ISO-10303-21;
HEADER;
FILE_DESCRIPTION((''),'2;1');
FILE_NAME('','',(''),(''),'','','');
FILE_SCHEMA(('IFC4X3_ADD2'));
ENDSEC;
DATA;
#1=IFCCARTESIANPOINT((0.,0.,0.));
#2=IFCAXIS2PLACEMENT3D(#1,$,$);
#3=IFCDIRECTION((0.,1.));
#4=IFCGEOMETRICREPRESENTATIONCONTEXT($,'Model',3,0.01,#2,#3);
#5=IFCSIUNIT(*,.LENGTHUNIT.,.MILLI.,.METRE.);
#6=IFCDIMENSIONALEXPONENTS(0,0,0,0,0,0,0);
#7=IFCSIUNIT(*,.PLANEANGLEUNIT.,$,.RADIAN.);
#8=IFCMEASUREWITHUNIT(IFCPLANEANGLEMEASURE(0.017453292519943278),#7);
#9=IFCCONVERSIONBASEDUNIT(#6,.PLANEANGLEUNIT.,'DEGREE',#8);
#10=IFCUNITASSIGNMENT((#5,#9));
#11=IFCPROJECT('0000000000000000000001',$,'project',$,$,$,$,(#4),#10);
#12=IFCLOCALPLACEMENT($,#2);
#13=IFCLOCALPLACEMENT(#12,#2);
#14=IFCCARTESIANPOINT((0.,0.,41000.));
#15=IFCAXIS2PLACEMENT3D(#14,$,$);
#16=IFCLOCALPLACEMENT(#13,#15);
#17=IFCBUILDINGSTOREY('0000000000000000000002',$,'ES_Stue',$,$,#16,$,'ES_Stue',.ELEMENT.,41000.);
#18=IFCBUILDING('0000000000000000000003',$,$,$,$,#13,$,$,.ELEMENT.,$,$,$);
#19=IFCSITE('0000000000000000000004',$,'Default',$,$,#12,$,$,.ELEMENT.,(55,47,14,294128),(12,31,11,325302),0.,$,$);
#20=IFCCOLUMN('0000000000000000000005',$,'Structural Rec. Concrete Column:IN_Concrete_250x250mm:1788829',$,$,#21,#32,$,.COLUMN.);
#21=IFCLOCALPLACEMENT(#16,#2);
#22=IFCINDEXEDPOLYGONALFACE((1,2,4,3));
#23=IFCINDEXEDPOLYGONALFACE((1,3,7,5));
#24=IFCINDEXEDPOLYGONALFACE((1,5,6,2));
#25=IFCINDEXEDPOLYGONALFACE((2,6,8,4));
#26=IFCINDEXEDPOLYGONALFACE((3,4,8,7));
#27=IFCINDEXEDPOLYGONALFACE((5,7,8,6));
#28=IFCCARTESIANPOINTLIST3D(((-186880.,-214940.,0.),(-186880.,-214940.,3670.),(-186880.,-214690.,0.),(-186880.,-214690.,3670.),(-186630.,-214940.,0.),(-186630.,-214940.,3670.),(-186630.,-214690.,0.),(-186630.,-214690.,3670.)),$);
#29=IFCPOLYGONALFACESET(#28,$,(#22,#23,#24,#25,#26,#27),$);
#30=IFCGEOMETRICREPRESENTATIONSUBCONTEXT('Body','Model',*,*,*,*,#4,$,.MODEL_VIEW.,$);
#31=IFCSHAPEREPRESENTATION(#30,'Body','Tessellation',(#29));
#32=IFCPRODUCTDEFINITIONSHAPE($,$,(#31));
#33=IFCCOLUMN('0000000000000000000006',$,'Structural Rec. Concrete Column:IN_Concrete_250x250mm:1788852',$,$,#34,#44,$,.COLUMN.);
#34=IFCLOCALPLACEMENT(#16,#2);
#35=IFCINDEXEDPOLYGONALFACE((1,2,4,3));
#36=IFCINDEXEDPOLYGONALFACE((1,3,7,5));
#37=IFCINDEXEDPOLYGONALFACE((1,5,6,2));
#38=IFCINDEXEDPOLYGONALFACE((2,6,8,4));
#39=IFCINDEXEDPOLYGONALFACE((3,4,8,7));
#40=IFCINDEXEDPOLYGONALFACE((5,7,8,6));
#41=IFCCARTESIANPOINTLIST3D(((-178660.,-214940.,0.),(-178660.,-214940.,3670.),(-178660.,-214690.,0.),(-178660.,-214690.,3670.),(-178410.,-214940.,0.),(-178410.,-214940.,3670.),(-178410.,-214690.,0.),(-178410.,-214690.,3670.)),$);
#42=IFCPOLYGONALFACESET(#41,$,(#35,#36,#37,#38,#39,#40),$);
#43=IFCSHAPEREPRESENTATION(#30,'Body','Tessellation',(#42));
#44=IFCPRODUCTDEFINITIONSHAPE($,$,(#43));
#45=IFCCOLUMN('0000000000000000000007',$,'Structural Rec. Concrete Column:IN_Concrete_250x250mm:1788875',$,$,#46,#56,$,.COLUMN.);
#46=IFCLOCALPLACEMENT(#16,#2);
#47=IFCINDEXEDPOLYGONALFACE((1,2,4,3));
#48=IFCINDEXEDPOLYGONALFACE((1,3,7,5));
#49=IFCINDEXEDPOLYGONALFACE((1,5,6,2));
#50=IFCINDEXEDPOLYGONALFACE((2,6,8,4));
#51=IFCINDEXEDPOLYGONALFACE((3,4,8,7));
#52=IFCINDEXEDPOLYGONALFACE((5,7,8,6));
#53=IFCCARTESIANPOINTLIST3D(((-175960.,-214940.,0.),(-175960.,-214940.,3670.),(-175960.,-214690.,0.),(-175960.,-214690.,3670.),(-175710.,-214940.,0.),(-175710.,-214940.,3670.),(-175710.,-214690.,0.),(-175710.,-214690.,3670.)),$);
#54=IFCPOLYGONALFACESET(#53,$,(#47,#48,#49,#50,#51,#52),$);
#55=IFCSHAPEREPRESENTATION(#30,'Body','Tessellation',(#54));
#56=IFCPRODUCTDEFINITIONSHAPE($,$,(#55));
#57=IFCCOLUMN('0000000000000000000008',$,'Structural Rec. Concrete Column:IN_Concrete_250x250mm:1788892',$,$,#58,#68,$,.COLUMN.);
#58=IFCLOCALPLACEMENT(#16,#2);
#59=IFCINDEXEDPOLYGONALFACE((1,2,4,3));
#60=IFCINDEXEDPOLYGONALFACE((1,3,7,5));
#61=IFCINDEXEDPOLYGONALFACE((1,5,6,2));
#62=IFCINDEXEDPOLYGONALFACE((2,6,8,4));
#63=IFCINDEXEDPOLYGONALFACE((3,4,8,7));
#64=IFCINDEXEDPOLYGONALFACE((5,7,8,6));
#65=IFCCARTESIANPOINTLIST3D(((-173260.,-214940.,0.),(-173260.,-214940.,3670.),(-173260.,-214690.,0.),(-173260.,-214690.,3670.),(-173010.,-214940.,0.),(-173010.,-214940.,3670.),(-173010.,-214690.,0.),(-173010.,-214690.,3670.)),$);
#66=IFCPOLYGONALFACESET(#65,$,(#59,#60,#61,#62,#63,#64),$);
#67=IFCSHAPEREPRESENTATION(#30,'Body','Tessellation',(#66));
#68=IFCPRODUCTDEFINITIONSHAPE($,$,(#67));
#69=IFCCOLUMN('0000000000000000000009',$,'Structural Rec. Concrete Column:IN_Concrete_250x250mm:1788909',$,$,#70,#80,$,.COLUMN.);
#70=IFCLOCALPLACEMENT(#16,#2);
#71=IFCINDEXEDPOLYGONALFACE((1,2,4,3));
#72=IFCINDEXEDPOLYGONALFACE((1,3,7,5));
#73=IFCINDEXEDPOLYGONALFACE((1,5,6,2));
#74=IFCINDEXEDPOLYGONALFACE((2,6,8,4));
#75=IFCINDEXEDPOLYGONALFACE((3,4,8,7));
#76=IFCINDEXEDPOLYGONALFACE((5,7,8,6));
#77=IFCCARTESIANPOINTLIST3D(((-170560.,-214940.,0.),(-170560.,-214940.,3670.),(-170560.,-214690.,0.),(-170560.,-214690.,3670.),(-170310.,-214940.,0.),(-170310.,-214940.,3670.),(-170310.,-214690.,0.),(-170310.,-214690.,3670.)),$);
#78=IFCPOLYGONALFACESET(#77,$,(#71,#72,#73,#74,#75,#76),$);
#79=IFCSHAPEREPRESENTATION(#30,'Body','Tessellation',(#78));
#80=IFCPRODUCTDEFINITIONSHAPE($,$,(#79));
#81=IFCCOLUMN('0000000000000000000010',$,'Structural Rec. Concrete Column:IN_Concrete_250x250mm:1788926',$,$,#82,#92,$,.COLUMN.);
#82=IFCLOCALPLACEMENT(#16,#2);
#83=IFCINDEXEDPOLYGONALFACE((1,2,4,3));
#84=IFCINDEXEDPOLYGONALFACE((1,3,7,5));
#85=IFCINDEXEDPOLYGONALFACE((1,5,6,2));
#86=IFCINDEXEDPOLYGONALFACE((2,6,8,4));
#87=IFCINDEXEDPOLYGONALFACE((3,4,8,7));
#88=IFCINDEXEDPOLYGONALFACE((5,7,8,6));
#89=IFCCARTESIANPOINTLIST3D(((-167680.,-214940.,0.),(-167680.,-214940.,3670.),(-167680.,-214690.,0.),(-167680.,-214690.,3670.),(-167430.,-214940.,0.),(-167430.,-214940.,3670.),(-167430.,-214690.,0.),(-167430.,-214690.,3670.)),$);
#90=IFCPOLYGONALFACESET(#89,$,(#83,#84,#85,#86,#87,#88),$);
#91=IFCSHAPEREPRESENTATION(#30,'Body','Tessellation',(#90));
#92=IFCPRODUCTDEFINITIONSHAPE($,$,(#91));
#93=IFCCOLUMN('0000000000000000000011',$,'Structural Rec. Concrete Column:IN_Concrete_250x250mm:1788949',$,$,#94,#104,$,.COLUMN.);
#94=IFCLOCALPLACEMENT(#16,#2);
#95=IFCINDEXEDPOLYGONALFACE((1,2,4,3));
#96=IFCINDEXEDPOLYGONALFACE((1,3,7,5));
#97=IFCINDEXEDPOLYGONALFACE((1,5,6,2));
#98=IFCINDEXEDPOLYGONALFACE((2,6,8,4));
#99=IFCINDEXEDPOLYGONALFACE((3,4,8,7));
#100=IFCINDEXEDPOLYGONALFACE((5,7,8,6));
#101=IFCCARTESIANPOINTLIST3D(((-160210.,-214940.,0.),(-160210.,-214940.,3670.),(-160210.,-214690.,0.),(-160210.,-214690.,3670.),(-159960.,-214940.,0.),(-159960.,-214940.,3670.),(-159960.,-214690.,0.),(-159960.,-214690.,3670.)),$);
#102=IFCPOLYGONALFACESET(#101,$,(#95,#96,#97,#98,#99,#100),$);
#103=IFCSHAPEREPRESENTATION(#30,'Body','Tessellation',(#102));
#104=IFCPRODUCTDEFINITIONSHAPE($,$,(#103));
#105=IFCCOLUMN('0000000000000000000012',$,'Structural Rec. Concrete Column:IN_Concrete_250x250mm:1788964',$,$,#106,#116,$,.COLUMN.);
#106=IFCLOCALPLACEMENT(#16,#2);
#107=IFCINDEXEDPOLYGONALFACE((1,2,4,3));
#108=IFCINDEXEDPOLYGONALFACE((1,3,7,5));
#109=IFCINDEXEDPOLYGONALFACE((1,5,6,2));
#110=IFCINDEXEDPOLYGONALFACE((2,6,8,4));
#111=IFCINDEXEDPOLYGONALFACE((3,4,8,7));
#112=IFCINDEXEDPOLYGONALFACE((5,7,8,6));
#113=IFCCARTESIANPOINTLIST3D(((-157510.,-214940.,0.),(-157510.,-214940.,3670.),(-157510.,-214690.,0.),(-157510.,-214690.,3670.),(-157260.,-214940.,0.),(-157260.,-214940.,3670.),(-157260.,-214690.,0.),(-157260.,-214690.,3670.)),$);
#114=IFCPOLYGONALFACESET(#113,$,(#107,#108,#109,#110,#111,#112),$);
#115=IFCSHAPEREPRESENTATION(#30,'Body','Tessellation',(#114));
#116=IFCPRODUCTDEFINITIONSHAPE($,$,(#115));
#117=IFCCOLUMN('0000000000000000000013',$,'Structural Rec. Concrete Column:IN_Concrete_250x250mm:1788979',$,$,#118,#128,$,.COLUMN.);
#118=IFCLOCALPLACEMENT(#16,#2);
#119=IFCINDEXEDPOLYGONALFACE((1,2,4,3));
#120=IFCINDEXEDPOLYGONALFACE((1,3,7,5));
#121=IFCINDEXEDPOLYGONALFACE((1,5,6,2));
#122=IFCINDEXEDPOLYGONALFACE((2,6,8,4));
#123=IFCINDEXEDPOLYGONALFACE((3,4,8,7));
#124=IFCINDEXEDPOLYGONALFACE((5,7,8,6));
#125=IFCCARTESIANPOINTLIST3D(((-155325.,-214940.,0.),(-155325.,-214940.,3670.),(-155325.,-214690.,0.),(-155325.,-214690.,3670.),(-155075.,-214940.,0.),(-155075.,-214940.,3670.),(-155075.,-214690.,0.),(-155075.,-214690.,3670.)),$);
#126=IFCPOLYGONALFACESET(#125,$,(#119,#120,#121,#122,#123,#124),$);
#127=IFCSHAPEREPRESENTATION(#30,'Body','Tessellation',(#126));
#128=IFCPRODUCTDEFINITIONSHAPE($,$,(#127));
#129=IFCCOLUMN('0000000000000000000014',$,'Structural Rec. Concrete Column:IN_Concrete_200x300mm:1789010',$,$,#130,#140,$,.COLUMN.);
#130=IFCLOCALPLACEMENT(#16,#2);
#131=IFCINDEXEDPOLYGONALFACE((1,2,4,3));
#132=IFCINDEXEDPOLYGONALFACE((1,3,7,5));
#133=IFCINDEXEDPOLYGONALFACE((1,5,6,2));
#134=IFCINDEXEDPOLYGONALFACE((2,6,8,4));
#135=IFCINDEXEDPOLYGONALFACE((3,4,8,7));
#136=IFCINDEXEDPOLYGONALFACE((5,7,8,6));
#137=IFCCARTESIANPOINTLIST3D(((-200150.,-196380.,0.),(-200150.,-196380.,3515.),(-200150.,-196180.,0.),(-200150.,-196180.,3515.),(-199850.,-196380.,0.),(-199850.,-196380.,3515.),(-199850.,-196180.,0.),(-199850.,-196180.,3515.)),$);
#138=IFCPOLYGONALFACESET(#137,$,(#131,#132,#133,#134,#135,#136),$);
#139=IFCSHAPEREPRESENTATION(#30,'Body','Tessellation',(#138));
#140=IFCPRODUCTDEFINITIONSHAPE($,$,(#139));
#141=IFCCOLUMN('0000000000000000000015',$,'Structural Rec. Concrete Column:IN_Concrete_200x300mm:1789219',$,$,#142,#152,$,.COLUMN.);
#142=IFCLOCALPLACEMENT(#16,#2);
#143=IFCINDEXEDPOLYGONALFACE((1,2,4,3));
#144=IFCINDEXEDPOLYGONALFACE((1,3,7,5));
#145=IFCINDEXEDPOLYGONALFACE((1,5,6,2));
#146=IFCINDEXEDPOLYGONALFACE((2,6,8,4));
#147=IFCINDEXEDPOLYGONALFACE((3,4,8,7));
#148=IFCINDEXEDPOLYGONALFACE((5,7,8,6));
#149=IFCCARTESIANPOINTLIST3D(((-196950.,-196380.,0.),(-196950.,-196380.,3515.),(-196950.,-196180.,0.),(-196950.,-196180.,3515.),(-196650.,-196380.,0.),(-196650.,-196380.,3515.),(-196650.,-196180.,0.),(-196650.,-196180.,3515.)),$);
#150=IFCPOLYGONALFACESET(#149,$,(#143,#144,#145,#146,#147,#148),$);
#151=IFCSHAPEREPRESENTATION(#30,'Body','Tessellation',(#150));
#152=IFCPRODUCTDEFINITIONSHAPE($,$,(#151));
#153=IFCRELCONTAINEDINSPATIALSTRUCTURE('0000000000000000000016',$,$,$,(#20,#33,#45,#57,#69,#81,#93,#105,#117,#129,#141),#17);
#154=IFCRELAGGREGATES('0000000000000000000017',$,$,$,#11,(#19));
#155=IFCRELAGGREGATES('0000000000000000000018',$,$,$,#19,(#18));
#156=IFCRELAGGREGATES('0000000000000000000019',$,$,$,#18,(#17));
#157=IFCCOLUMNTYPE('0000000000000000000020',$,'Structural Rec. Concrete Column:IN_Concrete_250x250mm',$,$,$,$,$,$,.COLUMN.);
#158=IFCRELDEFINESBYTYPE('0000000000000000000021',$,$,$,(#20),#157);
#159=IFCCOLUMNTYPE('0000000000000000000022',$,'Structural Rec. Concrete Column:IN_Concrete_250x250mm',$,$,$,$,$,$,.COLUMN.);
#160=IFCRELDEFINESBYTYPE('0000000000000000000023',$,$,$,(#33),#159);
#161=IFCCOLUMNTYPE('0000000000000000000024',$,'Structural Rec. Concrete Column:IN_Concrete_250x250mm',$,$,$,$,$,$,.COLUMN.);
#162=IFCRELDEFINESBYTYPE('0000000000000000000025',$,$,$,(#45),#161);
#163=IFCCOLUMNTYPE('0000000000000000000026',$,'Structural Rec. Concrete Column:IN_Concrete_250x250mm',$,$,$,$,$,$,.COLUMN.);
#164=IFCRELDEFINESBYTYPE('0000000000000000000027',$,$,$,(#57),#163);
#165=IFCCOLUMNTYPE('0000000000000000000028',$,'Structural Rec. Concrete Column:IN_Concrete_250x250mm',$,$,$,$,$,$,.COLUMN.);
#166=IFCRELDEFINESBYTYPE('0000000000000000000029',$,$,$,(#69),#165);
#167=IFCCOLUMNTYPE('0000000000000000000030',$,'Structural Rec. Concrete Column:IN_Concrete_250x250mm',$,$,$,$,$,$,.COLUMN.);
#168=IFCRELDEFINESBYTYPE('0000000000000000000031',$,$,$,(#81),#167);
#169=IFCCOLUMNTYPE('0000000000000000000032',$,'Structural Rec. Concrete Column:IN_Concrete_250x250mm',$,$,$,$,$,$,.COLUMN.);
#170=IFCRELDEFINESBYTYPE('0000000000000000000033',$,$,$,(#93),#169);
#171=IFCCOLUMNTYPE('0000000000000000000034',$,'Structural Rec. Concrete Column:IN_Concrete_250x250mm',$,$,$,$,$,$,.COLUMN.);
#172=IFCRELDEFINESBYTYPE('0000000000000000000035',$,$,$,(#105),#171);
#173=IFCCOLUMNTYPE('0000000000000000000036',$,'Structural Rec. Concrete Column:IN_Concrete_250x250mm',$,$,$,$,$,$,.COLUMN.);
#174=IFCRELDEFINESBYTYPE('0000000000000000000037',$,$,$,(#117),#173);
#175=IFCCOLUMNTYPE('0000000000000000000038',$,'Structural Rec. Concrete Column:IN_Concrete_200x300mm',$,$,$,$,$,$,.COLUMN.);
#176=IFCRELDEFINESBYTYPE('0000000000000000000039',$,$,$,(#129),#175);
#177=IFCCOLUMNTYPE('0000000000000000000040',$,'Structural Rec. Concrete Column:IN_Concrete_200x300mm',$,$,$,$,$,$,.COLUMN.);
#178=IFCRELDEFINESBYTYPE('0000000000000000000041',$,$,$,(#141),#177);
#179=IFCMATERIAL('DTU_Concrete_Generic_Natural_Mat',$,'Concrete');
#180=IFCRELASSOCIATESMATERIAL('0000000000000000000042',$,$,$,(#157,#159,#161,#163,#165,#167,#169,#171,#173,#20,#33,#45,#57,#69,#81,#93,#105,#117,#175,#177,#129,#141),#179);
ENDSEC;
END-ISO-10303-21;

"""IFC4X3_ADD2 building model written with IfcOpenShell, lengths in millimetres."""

from ifc_helpers import new_model, entity, si_unit, converted_unit, direction, frame, frame_2d, origin, place, context, subcontext, project, spatial, rectangle, extrude, source, transform, mapped, material, material_profile, profile_set, profile_usage, type_object, type_shapes, element, save


model = new_model("IFC4X3_ADD2")

# Units and contexts
model_context = context("Model", 3, precision=0.01, world=origin(), true_north=direction((0.0, 1.0)))
body_context = subcontext(model_context, "Body", "Model", "MODEL_VIEW")
ifc_project = project(units=[si_unit("LENGTHUNIT", "METRE", prefix="MILLI"), converted_unit("PLANEANGLEUNIT", "DEGREE", entity("IfcPlaneAngleMeasure", 0.017453292519943278), si_unit("PLANEANGLEUNIT", "RADIAN"), dimensions=[0, 0, 0, 0, 0, 0, 0])], contexts=[model_context])

# Site, building, storey
site_placement = place(None, origin())
site = spatial("IfcSite", under=ifc_project, at=site_placement, Name="Default", CompositionType="ELEMENT", RefLatitude=(55, 47, 14, 294128), RefLongitude=(12, 31, 11, 325302), RefElevation=0.0)
building_placement = place(site_placement, origin())
building = spatial("IfcBuilding", under=site, at=building_placement, CompositionType="ELEMENT")
storey_placement = place(building_placement, frame((0.0, 0.0, 41000.0)))
storey = spatial("IfcBuildingStorey", under=building, at=storey_placement, Name="ES_Stue", LongName="ES_Stue", CompositionType="ELEMENT", Elevation=41000.0)

# Columns
ifc_material = material(Name="DTU_Concrete_Generic_Natural_Mat", Category="Concrete")
ifc_material_profile_1 = material_profile(ifc_material, rectangle(XDim=250.0, YDim=250.0, at=frame_2d((0.0, 0.0), x_axis=(1.0, 0.0))), Name="IN_Concrete_250x250mm")
ifc_profile_set_1 = profile_set([ifc_material_profile_1], Name="IN_Concrete_250x250mm")
ifc_profile_usage_1 = profile_usage(ifc_profile_set_1)
column_type_1 = type_object("IfcColumnType", Name="Structural Rec. Concrete Column:IN_Concrete_250x250mm", PredefinedType="COLUMN", material=ifc_profile_set_1)
shared_shape_1 = source(origin(), body_context, "Body", "SweptSolid", [
    extrude(rectangle(XDim=250.0, YDim=250.0, at=frame_2d((0.0, 0.0), x_axis=(1.0, 0.0))), frame((-186755.0, -214815.0, 41000.0), z_axis=(0.0, 0.0, 1.0), x_axis=(-1.0, 0.0, 0.0)), (0.0, 0.0, 1.0), 3670.0),
])
type_shapes(column_type_1, [shared_shape_1])
column_1_placement = place(storey_placement, frame((0.0, 0.0, -41000.0)))
element("IfcColumn", 1, at=column_1_placement, inside=storey, type_object=column_type_1, material=ifc_profile_usage_1, Name="Structural Rec. Concrete Column:IN_Concrete_250x250mm:1788829", PredefinedType="COLUMN", context=body_context, shape_type="MappedRepresentation", body=[
    mapped(shared_shape_1, transform((0.0, 0.0, 0.0), scale=1.0)),
])
column_type_2 = type_object("IfcColumnType", Name="Structural Rec. Concrete Column:IN_Concrete_250x250mm", PredefinedType="COLUMN", material=ifc_profile_set_1)
shared_shape_2 = source(origin(), body_context, "Body", "SweptSolid", [
    extrude(rectangle(XDim=250.0, YDim=250.0, at=frame_2d((0.0, 0.0), x_axis=(1.0, 0.0))), frame((-178535.0, -214815.0, 41000.0), z_axis=(0.0, 0.0, 1.0), x_axis=(-1.0, 0.0, 0.0)), (0.0, 0.0, 1.0), 3670.0),
])
type_shapes(column_type_2, [shared_shape_2])
column_2_placement = place(storey_placement, frame((0.0, 0.0, -41000.0)))
element("IfcColumn", 2, at=column_2_placement, inside=storey, type_object=column_type_2, material=ifc_profile_usage_1, Name="Structural Rec. Concrete Column:IN_Concrete_250x250mm:1788852", PredefinedType="COLUMN", context=body_context, shape_type="MappedRepresentation", body=[
    mapped(shared_shape_2, transform((0.0, 0.0, 0.0), scale=1.0)),
])
column_type_3 = type_object("IfcColumnType", Name="Structural Rec. Concrete Column:IN_Concrete_250x250mm", PredefinedType="COLUMN", material=ifc_profile_set_1)
shared_shape_3 = source(origin(), body_context, "Body", "SweptSolid", [
    extrude(rectangle(XDim=250.0, YDim=250.0, at=frame_2d((0.0, 0.0), x_axis=(1.0, 0.0))), frame((-175835.0, -214815.0, 41000.0), z_axis=(0.0, 0.0, 1.0), x_axis=(-1.0, 0.0, 0.0)), (0.0, 0.0, 1.0), 3670.0),
])
type_shapes(column_type_3, [shared_shape_3])
column_3_placement = place(storey_placement, frame((0.0, 0.0, -41000.0)))
element("IfcColumn", 3, at=column_3_placement, inside=storey, type_object=column_type_3, material=ifc_profile_usage_1, Name="Structural Rec. Concrete Column:IN_Concrete_250x250mm:1788875", PredefinedType="COLUMN", context=body_context, shape_type="MappedRepresentation", body=[
    mapped(shared_shape_3, transform((0.0, 0.0, 0.0), scale=1.0)),
])
column_type_4 = type_object("IfcColumnType", Name="Structural Rec. Concrete Column:IN_Concrete_250x250mm", PredefinedType="COLUMN", material=ifc_profile_set_1)
shared_shape_4 = source(origin(), body_context, "Body", "SweptSolid", [
    extrude(rectangle(XDim=250.0, YDim=250.0, at=frame_2d((0.0, 0.0), x_axis=(1.0, 0.0))), frame((-173135.0, -214815.0, 41000.0), z_axis=(0.0, 0.0, 1.0), x_axis=(-1.0, 0.0, 0.0)), (0.0, 0.0, 1.0), 3670.0),
])
type_shapes(column_type_4, [shared_shape_4])
column_4_placement = place(storey_placement, frame((0.0, 0.0, -41000.0)))
element("IfcColumn", 4, at=column_4_placement, inside=storey, type_object=column_type_4, material=ifc_profile_usage_1, Name="Structural Rec. Concrete Column:IN_Concrete_250x250mm:1788892", PredefinedType="COLUMN", context=body_context, shape_type="MappedRepresentation", body=[
    mapped(shared_shape_4, transform((0.0, 0.0, 0.0), scale=1.0)),
])
column_type_5 = type_object("IfcColumnType", Name="Structural Rec. Concrete Column:IN_Concrete_250x250mm", PredefinedType="COLUMN", material=ifc_profile_set_1)
shared_shape_5 = source(origin(), body_context, "Body", "SweptSolid", [
    extrude(rectangle(XDim=250.0, YDim=250.0, at=frame_2d((0.0, 0.0), x_axis=(1.0, 0.0))), frame((-170435.0, -214815.0, 41000.0), z_axis=(0.0, 0.0, 1.0), x_axis=(-1.0, 0.0, 0.0)), (0.0, 0.0, 1.0), 3670.0),
])
type_shapes(column_type_5, [shared_shape_5])
column_5_placement = place(storey_placement, frame((0.0, 0.0, -41000.0)))
element("IfcColumn", 5, at=column_5_placement, inside=storey, type_object=column_type_5, material=ifc_profile_usage_1, Name="Structural Rec. Concrete Column:IN_Concrete_250x250mm:1788909", PredefinedType="COLUMN", context=body_context, shape_type="MappedRepresentation", body=[
    mapped(shared_shape_5, transform((0.0, 0.0, 0.0), scale=1.0)),
])
column_type_6 = type_object("IfcColumnType", Name="Structural Rec. Concrete Column:IN_Concrete_250x250mm", PredefinedType="COLUMN", material=ifc_profile_set_1)
shared_shape_6 = source(origin(), body_context, "Body", "SweptSolid", [
    extrude(rectangle(XDim=250.0, YDim=250.0, at=frame_2d((0.0, 0.0), x_axis=(1.0, 0.0))), frame((-167555.0, -214815.0, 41000.0), z_axis=(0.0, 0.0, 1.0), x_axis=(-1.0, 0.0, 0.0)), (0.0, 0.0, 1.0), 3670.0),
])
type_shapes(column_type_6, [shared_shape_6])
column_6_placement = place(storey_placement, frame((0.0, 0.0, -41000.0)))
element("IfcColumn", 6, at=column_6_placement, inside=storey, type_object=column_type_6, material=ifc_profile_usage_1, Name="Structural Rec. Concrete Column:IN_Concrete_250x250mm:1788926", PredefinedType="COLUMN", context=body_context, shape_type="MappedRepresentation", body=[
    mapped(shared_shape_6, transform((0.0, 0.0, 0.0), scale=1.0)),
])
column_type_7 = type_object("IfcColumnType", Name="Structural Rec. Concrete Column:IN_Concrete_250x250mm", PredefinedType="COLUMN", material=ifc_profile_set_1)
shared_shape_7 = source(origin(), body_context, "Body", "SweptSolid", [
    extrude(rectangle(XDim=250.0, YDim=250.0, at=frame_2d((0.0, 0.0), x_axis=(1.0, 0.0))), frame((-160085.0, -214815.0, 41000.0), z_axis=(0.0, 0.0, 1.0), x_axis=(-1.0, 0.0, 0.0)), (0.0, 0.0, 1.0), 3670.0),
])
type_shapes(column_type_7, [shared_shape_7])
column_7_placement = place(storey_placement, frame((0.0, 0.0, -41000.0)))
element("IfcColumn", 7, at=column_7_placement, inside=storey, type_object=column_type_7, material=ifc_profile_usage_1, Name="Structural Rec. Concrete Column:IN_Concrete_250x250mm:1788949", PredefinedType="COLUMN", context=body_context, shape_type="MappedRepresentation", body=[
    mapped(shared_shape_7, transform((0.0, 0.0, 0.0), scale=1.0)),
])
column_type_8 = type_object("IfcColumnType", Name="Structural Rec. Concrete Column:IN_Concrete_250x250mm", PredefinedType="COLUMN", material=ifc_profile_set_1)
shared_shape_8 = source(origin(), body_context, "Body", "SweptSolid", [
    extrude(rectangle(XDim=250.0, YDim=250.0, at=frame_2d((0.0, 0.0), x_axis=(1.0, 0.0))), frame((-157385.0, -214815.0, 41000.0), z_axis=(0.0, 0.0, 1.0), x_axis=(-1.0, 0.0, 0.0)), (0.0, 0.0, 1.0), 3670.0),
])
type_shapes(column_type_8, [shared_shape_8])
column_8_placement = place(storey_placement, frame((0.0, 0.0, -41000.0)))
element("IfcColumn", 8, at=column_8_placement, inside=storey, type_object=column_type_8, material=ifc_profile_usage_1, Name="Structural Rec. Concrete Column:IN_Concrete_250x250mm:1788964", PredefinedType="COLUMN", context=body_context, shape_type="MappedRepresentation", body=[
    mapped(shared_shape_8, transform((0.0, 0.0, 0.0), scale=1.0)),
])
column_type_9 = type_object("IfcColumnType", Name="Structural Rec. Concrete Column:IN_Concrete_250x250mm", PredefinedType="COLUMN", material=ifc_profile_set_1)
shared_shape_9 = source(origin(), body_context, "Body", "SweptSolid", [
    extrude(rectangle(XDim=250.0, YDim=250.0, at=frame_2d((0.0, 0.0), x_axis=(1.0, 0.0))), frame((-155200.0, -214815.0, 41000.0), z_axis=(0.0, 0.0, 1.0), x_axis=(-1.0, 0.0, 0.0)), (0.0, 0.0, 1.0), 3670.0),
])
type_shapes(column_type_9, [shared_shape_9])
column_9_placement = place(storey_placement, frame((0.0, 0.0, -41000.0)))
element("IfcColumn", 9, at=column_9_placement, inside=storey, type_object=column_type_9, material=ifc_profile_usage_1, Name="Structural Rec. Concrete Column:IN_Concrete_250x250mm:1788979", PredefinedType="COLUMN", context=body_context, shape_type="MappedRepresentation", body=[
    mapped(shared_shape_9, transform((0.0, 0.0, 0.0), scale=1.0)),
])
ifc_material_profile_2 = material_profile(ifc_material, rectangle(XDim=200.0, YDim=300.0, at=frame_2d((0.0, 0.0), x_axis=(1.0, 0.0))), Name="IN_Concrete_200x300mm")
ifc_profile_set_2 = profile_set([ifc_material_profile_2], Name="IN_Concrete_200x300mm")
ifc_profile_usage_2 = profile_usage(ifc_profile_set_2)
column_type_10 = type_object("IfcColumnType", Name="Structural Rec. Concrete Column:IN_Concrete_200x300mm", PredefinedType="COLUMN", material=ifc_profile_set_2)
shared_shape_10 = source(origin(), body_context, "Body", "SweptSolid", [
    extrude(rectangle(XDim=200.0, YDim=300.0, at=frame_2d((0.0, 0.0), x_axis=(1.0, 0.0))), frame((-200000.0, -196280.0, 41000.0), z_axis=(0.0, 0.0, 1.0), x_axis=(0.0, -1.0, 0.0)), (0.0, 0.0, 1.0), 3515.0),
])
type_shapes(column_type_10, [shared_shape_10])
column_10_placement = place(storey_placement, frame((0.0, 0.0, -41000.0)))
element("IfcColumn", 10, at=column_10_placement, inside=storey, type_object=column_type_10, material=ifc_profile_usage_2, Name="Structural Rec. Concrete Column:IN_Concrete_200x300mm:1789010", PredefinedType="COLUMN", context=body_context, shape_type="MappedRepresentation", body=[
    mapped(shared_shape_10, transform((0.0, 0.0, 0.0), scale=1.0)),
])
column_type_11 = type_object("IfcColumnType", Name="Structural Rec. Concrete Column:IN_Concrete_200x300mm", PredefinedType="COLUMN", material=ifc_profile_set_2)
shared_shape_11 = source(origin(), body_context, "Body", "SweptSolid", [
    extrude(rectangle(XDim=200.0, YDim=300.0, at=frame_2d((0.0, 0.0), x_axis=(1.0, 0.0))), frame((-196800.0, -196280.0, 41000.0), z_axis=(0.0, 0.0, 1.0), x_axis=(0.0, -1.0, 0.0)), (0.0, 0.0, 1.0), 3515.0),
])
type_shapes(column_type_11, [shared_shape_11])
column_11_placement = place(storey_placement, frame((0.0, 0.0, -41000.0)))
element("IfcColumn", 11, at=column_11_placement, inside=storey, type_object=column_type_11, material=ifc_profile_usage_2, Name="Structural Rec. Concrete Column:IN_Concrete_200x300mm:1789219", PredefinedType="COLUMN", context=body_context, shape_type="MappedRepresentation", body=[
    mapped(shared_shape_11, transform((0.0, 0.0, 0.0), scale=1.0)),
])

save(model, "model.ifc")
